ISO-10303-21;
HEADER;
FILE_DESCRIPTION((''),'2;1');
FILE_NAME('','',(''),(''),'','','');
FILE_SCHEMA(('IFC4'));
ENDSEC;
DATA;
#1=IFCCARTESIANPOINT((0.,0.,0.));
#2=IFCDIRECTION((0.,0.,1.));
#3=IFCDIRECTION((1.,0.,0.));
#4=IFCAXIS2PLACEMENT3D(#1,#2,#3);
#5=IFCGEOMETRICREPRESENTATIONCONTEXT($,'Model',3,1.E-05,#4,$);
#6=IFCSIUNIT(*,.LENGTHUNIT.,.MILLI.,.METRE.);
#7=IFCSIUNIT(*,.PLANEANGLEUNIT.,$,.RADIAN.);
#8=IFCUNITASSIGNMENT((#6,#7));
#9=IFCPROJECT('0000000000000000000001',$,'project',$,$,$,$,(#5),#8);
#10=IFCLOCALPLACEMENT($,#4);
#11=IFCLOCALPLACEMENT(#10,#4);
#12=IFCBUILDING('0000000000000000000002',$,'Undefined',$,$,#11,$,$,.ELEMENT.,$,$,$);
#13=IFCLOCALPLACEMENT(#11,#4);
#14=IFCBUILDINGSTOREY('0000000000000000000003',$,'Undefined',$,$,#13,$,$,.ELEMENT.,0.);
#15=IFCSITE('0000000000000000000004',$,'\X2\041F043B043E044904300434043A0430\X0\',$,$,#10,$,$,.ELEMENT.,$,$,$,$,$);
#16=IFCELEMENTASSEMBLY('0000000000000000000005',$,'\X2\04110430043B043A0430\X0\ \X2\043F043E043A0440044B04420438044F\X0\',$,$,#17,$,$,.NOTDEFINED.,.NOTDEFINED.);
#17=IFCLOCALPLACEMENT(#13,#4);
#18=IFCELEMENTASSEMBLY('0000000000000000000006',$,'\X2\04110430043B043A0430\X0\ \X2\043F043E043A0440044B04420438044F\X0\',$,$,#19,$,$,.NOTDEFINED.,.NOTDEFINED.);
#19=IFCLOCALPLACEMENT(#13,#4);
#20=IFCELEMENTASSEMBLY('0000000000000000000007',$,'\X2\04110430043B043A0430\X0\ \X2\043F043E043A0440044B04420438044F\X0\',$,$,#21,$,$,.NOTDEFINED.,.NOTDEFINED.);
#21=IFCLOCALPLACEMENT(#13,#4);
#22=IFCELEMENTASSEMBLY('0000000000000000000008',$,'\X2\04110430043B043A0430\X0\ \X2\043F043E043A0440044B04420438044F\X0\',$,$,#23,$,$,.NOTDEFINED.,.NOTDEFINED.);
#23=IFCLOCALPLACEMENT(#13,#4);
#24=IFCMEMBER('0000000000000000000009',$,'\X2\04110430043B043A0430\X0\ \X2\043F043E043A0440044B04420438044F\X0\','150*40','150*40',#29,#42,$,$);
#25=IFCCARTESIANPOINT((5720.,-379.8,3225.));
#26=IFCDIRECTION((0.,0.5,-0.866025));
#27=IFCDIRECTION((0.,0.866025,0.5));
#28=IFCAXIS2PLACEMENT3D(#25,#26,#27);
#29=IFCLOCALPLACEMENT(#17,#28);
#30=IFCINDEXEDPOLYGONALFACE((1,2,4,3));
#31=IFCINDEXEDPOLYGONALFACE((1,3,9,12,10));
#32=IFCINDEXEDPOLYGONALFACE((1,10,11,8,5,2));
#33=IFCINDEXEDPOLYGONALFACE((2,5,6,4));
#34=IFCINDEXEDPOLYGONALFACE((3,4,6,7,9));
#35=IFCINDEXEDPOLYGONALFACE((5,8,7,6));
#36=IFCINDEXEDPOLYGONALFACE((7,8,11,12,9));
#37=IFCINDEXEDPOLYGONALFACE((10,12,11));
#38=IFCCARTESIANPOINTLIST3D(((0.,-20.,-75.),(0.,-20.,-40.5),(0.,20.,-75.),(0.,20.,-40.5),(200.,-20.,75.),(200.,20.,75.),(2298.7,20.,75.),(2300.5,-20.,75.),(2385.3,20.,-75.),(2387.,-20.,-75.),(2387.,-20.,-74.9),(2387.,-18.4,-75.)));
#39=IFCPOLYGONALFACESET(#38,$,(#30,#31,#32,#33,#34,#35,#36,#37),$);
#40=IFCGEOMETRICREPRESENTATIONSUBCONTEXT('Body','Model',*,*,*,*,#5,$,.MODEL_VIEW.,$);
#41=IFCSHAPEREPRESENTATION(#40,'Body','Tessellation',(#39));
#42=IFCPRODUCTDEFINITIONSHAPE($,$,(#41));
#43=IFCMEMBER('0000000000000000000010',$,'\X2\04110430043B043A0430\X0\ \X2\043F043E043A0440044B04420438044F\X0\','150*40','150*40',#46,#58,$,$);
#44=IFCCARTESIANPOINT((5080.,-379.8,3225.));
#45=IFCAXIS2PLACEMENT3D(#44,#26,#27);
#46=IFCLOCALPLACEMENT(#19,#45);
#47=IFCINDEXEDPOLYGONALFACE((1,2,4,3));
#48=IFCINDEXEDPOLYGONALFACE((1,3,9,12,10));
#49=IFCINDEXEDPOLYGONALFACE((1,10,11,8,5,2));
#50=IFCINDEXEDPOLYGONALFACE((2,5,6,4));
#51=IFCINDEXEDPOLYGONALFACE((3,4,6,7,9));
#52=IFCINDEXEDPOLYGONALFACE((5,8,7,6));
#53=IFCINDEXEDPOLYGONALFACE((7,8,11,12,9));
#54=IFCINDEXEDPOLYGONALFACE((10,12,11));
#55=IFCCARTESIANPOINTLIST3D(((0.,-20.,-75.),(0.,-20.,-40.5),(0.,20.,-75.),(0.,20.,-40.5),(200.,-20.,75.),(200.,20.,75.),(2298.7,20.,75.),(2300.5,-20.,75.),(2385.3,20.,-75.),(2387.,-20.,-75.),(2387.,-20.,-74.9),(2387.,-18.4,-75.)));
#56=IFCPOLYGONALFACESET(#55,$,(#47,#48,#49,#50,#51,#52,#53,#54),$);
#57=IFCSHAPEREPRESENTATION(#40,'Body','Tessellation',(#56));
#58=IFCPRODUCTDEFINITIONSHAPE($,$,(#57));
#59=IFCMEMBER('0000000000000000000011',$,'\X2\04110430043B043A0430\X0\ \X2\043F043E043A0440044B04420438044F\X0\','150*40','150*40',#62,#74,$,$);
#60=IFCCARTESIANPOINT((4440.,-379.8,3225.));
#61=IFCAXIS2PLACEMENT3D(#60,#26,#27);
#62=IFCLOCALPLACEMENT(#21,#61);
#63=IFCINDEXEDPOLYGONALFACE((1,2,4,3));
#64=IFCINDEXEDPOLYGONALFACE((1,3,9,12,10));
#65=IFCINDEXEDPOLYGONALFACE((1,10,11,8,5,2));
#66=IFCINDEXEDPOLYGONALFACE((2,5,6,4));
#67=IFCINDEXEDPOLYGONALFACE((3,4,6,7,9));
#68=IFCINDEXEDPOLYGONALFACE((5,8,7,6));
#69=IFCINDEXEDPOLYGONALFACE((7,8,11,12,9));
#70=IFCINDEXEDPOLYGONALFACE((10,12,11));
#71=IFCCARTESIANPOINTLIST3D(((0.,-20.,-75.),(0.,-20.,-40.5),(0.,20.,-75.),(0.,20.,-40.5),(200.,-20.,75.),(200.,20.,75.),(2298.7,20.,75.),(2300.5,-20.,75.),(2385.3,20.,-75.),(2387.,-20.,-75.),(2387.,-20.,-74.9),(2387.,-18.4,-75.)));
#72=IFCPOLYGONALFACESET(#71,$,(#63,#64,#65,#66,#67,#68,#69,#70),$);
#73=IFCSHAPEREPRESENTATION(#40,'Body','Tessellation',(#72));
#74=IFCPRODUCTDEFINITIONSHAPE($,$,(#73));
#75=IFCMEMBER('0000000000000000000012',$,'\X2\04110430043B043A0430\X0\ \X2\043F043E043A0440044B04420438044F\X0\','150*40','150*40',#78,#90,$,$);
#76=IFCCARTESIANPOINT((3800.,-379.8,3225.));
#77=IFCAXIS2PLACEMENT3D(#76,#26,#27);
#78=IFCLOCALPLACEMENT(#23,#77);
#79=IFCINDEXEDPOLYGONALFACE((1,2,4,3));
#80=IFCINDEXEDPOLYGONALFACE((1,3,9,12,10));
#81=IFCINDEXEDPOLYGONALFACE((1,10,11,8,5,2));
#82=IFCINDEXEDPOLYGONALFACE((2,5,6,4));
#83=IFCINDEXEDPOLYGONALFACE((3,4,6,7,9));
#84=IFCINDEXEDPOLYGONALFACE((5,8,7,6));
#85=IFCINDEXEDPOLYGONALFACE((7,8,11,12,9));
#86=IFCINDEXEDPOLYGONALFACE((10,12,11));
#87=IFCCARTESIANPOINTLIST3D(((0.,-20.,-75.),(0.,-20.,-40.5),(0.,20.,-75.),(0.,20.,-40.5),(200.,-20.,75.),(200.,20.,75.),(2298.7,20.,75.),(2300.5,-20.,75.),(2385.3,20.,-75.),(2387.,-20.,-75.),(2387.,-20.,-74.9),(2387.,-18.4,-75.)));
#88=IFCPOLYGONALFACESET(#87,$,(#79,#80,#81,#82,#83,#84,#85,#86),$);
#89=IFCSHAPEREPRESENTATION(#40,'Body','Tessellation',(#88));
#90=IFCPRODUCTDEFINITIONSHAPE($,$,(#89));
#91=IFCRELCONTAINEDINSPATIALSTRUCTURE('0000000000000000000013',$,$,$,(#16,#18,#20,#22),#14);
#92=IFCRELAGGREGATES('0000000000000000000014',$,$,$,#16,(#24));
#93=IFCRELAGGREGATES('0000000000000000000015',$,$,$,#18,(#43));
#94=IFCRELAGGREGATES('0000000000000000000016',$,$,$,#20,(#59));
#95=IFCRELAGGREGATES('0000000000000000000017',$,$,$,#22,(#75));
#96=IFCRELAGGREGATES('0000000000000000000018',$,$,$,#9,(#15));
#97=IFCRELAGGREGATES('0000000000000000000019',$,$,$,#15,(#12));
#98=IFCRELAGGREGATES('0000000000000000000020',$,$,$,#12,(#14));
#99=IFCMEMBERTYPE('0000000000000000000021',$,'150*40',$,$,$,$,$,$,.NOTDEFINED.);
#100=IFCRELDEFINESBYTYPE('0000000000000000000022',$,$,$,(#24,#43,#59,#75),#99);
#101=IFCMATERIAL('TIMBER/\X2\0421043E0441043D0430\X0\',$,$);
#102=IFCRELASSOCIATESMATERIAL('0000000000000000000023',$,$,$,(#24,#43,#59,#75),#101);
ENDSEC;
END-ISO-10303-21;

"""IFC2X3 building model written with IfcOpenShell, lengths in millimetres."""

from ifc_helpers import new_model, si_unit, frame, origin_with_axes, origin_2d_with_axis, place, context, subcontext, project, spatial, rectangle, extrude, boolean, halfspace, material, type_object, element, aggregate, save


model = new_model("IFC2X3")

# Units and contexts
model_context = context("Model", 3, precision=1e-05, world=origin_with_axes())
body_context = subcontext(model_context, "Body", "Model", "MODEL_VIEW")
ifc_project = project(units=[si_unit("LENGTHUNIT", "METRE", prefix="MILLI"), si_unit("PLANEANGLEUNIT", "RADIAN")], contexts=[model_context])

# Site, building, storey
site_placement = place(None, origin_with_axes())
site = spatial("IfcSite", under=ifc_project, at=site_placement, Name="Площадка", CompositionType="ELEMENT")
building_placement = place(site_placement, origin_with_axes())
building = spatial("IfcBuilding", under=site, at=building_placement, Name="Undefined", CompositionType="ELEMENT")
storey_placement = place(building_placement, origin_with_axes())
storey = spatial("IfcBuildingStorey", under=building, at=storey_placement, Name="Undefined", CompositionType="ELEMENT", Elevation=0.0)

# Shared definitions
ifc_material = material(Name="TIMBER/Сосна")

# Element assemblies
assembly_1_placement = place(storey_placement, origin_with_axes())
assembly_1 = element("IfcElementAssembly", 1, at=assembly_1_placement, inside=storey, Name="Балка покрытия", AssemblyPlace="NOTDEFINED", PredefinedType="NOTDEFINED")
assembly_2_placement = place(storey_placement, origin_with_axes())
assembly_2 = element("IfcElementAssembly", 2, at=assembly_2_placement, inside=storey, Name="Балка покрытия", AssemblyPlace="NOTDEFINED", PredefinedType="NOTDEFINED")
assembly_3_placement = place(storey_placement, origin_with_axes())
assembly_3 = element("IfcElementAssembly", 3, at=assembly_3_placement, inside=storey, Name="Балка покрытия", AssemblyPlace="NOTDEFINED", PredefinedType="NOTDEFINED")
assembly_4_placement = place(storey_placement, origin_with_axes())
assembly_4 = element("IfcElementAssembly", 4, at=assembly_4_placement, inside=storey, Name="Балка покрытия", AssemblyPlace="NOTDEFINED", PredefinedType="NOTDEFINED")

# Members
member_type = type_object("IfcMemberType", Name="150*40", PredefinedType="NOTDEFINED")
member_1_placement = place(assembly_1_placement, frame((5720.0, -379.8, 3225.0), z_axis=(0.0, 0.5, -0.866025), x_axis=(0.0, 0.866025, 0.5)))
member_1 = element("IfcMember", 5, at=member_1_placement, type_object=member_type, material=ifc_material, Name="Балка покрытия", Description="150*40", ObjectType="150*40", context=body_context, shape_type="CSG", body=[
    boolean("DIFFERENCE", boolean("DIFFERENCE", extrude(rectangle(XDim=40.0, YDim=150.0, at=origin_2d_with_axis()), frame((2387.0, 0.0, 0.0), z_axis=(-1.0, 0.0, 0.0), x_axis=(0.0, -1.0, 0.0)), (0.0, 0.0, 1.0), 2387.0), extrude(rectangle(XDim=40.0, YDim=150.0, at=origin_2d_with_axis()), frame((3513.2, 0.0, 2074.5), z_axis=(-0.866025, 0.0, -0.5), x_axis=(0.0, -1.0, 0.0)), (0.0, 0.0, 1.0), 4100.0)), halfspace(frame((2298.7, 20.0, 75.0), z_axis=(0.86539, 0.038305, 0.499633), x_axis=(0.5, 0.0, -0.866025)), False)),
])
aggregate(assembly_1, [member_1])
member_2_placement = place(assembly_2_placement, frame((5080.0, -379.8, 3225.0), z_axis=(0.0, 0.5, -0.866025), x_axis=(0.0, 0.866025, 0.5)))
member_2 = element("IfcMember", 6, at=member_2_placement, type_object=member_type, material=ifc_material, Name="Балка покрытия", Description="150*40", ObjectType="150*40", context=body_context, shape_type="CSG", body=[
    boolean("DIFFERENCE", boolean("DIFFERENCE", extrude(rectangle(XDim=40.0, YDim=150.0, at=origin_2d_with_axis()), frame((2387.0, 0.0, 0.0), z_axis=(-1.0, 0.0, 0.0), x_axis=(0.0, -1.0, 0.0)), (0.0, 0.0, 1.0), 2387.0), extrude(rectangle(XDim=40.0, YDim=150.0, at=origin_2d_with_axis()), frame((3513.2, 0.0, 2074.5), z_axis=(-0.866025, 0.0, -0.5), x_axis=(0.0, -1.0, 0.0)), (0.0, 0.0, 1.0), 4100.0)), halfspace(frame((2298.7, 20.0, 75.0), z_axis=(0.86539, 0.038305, 0.499633), x_axis=(0.5, 0.0, -0.866025)), False)),
])
aggregate(assembly_2, [member_2])
member_3_placement = place(assembly_3_placement, frame((4440.0, -379.8, 3225.0), z_axis=(0.0, 0.5, -0.866025), x_axis=(0.0, 0.866025, 0.5)))
member_3 = element("IfcMember", 7, at=member_3_placement, type_object=member_type, material=ifc_material, Name="Балка покрытия", Description="150*40", ObjectType="150*40", context=body_context, shape_type="CSG", body=[
    boolean("DIFFERENCE", boolean("DIFFERENCE", extrude(rectangle(XDim=40.0, YDim=150.0, at=origin_2d_with_axis()), frame((2387.0, 0.0, 0.0), z_axis=(-1.0, 0.0, 0.0), x_axis=(0.0, -1.0, 0.0)), (0.0, 0.0, 1.0), 2387.0), extrude(rectangle(XDim=40.0, YDim=150.0, at=origin_2d_with_axis()), frame((3513.2, 0.0, 2074.5), z_axis=(-0.866025, 0.0, -0.5), x_axis=(0.0, -1.0, 0.0)), (0.0, 0.0, 1.0), 4100.0)), halfspace(frame((2298.7, 20.0, 75.0), z_axis=(0.86539, 0.038305, 0.499633), x_axis=(0.5, 0.0, -0.866025)), False)),
])
aggregate(assembly_3, [member_3])
member_4_placement = place(assembly_4_placement, frame((3800.0, -379.8, 3225.0), z_axis=(0.0, 0.5, -0.866025), x_axis=(0.0, 0.866025, 0.5)))
member_4 = element("IfcMember", 8, at=member_4_placement, type_object=member_type, material=ifc_material, Name="Балка покрытия", Description="150*40", ObjectType="150*40", context=body_context, shape_type="CSG", body=[
    boolean("DIFFERENCE", boolean("DIFFERENCE", extrude(rectangle(XDim=40.0, YDim=150.0, at=origin_2d_with_axis()), frame((2387.0, 0.0, 0.0), z_axis=(-1.0, 0.0, 0.0), x_axis=(0.0, -1.0, 0.0)), (0.0, 0.0, 1.0), 2387.0), extrude(rectangle(XDim=40.0, YDim=150.0, at=origin_2d_with_axis()), frame((3513.2, 0.0, 2074.5), z_axis=(-0.866025, 0.0, -0.5), x_axis=(0.0, -1.0, 0.0)), (0.0, 0.0, 1.0), 4100.0)), halfspace(frame((2298.7, 20.0, 75.0), z_axis=(0.86539, 0.038305, 0.499633), x_axis=(0.5, 0.0, -0.866025)), False)),
])
aggregate(assembly_4, [member_4])

save(model, "model.ifc")
